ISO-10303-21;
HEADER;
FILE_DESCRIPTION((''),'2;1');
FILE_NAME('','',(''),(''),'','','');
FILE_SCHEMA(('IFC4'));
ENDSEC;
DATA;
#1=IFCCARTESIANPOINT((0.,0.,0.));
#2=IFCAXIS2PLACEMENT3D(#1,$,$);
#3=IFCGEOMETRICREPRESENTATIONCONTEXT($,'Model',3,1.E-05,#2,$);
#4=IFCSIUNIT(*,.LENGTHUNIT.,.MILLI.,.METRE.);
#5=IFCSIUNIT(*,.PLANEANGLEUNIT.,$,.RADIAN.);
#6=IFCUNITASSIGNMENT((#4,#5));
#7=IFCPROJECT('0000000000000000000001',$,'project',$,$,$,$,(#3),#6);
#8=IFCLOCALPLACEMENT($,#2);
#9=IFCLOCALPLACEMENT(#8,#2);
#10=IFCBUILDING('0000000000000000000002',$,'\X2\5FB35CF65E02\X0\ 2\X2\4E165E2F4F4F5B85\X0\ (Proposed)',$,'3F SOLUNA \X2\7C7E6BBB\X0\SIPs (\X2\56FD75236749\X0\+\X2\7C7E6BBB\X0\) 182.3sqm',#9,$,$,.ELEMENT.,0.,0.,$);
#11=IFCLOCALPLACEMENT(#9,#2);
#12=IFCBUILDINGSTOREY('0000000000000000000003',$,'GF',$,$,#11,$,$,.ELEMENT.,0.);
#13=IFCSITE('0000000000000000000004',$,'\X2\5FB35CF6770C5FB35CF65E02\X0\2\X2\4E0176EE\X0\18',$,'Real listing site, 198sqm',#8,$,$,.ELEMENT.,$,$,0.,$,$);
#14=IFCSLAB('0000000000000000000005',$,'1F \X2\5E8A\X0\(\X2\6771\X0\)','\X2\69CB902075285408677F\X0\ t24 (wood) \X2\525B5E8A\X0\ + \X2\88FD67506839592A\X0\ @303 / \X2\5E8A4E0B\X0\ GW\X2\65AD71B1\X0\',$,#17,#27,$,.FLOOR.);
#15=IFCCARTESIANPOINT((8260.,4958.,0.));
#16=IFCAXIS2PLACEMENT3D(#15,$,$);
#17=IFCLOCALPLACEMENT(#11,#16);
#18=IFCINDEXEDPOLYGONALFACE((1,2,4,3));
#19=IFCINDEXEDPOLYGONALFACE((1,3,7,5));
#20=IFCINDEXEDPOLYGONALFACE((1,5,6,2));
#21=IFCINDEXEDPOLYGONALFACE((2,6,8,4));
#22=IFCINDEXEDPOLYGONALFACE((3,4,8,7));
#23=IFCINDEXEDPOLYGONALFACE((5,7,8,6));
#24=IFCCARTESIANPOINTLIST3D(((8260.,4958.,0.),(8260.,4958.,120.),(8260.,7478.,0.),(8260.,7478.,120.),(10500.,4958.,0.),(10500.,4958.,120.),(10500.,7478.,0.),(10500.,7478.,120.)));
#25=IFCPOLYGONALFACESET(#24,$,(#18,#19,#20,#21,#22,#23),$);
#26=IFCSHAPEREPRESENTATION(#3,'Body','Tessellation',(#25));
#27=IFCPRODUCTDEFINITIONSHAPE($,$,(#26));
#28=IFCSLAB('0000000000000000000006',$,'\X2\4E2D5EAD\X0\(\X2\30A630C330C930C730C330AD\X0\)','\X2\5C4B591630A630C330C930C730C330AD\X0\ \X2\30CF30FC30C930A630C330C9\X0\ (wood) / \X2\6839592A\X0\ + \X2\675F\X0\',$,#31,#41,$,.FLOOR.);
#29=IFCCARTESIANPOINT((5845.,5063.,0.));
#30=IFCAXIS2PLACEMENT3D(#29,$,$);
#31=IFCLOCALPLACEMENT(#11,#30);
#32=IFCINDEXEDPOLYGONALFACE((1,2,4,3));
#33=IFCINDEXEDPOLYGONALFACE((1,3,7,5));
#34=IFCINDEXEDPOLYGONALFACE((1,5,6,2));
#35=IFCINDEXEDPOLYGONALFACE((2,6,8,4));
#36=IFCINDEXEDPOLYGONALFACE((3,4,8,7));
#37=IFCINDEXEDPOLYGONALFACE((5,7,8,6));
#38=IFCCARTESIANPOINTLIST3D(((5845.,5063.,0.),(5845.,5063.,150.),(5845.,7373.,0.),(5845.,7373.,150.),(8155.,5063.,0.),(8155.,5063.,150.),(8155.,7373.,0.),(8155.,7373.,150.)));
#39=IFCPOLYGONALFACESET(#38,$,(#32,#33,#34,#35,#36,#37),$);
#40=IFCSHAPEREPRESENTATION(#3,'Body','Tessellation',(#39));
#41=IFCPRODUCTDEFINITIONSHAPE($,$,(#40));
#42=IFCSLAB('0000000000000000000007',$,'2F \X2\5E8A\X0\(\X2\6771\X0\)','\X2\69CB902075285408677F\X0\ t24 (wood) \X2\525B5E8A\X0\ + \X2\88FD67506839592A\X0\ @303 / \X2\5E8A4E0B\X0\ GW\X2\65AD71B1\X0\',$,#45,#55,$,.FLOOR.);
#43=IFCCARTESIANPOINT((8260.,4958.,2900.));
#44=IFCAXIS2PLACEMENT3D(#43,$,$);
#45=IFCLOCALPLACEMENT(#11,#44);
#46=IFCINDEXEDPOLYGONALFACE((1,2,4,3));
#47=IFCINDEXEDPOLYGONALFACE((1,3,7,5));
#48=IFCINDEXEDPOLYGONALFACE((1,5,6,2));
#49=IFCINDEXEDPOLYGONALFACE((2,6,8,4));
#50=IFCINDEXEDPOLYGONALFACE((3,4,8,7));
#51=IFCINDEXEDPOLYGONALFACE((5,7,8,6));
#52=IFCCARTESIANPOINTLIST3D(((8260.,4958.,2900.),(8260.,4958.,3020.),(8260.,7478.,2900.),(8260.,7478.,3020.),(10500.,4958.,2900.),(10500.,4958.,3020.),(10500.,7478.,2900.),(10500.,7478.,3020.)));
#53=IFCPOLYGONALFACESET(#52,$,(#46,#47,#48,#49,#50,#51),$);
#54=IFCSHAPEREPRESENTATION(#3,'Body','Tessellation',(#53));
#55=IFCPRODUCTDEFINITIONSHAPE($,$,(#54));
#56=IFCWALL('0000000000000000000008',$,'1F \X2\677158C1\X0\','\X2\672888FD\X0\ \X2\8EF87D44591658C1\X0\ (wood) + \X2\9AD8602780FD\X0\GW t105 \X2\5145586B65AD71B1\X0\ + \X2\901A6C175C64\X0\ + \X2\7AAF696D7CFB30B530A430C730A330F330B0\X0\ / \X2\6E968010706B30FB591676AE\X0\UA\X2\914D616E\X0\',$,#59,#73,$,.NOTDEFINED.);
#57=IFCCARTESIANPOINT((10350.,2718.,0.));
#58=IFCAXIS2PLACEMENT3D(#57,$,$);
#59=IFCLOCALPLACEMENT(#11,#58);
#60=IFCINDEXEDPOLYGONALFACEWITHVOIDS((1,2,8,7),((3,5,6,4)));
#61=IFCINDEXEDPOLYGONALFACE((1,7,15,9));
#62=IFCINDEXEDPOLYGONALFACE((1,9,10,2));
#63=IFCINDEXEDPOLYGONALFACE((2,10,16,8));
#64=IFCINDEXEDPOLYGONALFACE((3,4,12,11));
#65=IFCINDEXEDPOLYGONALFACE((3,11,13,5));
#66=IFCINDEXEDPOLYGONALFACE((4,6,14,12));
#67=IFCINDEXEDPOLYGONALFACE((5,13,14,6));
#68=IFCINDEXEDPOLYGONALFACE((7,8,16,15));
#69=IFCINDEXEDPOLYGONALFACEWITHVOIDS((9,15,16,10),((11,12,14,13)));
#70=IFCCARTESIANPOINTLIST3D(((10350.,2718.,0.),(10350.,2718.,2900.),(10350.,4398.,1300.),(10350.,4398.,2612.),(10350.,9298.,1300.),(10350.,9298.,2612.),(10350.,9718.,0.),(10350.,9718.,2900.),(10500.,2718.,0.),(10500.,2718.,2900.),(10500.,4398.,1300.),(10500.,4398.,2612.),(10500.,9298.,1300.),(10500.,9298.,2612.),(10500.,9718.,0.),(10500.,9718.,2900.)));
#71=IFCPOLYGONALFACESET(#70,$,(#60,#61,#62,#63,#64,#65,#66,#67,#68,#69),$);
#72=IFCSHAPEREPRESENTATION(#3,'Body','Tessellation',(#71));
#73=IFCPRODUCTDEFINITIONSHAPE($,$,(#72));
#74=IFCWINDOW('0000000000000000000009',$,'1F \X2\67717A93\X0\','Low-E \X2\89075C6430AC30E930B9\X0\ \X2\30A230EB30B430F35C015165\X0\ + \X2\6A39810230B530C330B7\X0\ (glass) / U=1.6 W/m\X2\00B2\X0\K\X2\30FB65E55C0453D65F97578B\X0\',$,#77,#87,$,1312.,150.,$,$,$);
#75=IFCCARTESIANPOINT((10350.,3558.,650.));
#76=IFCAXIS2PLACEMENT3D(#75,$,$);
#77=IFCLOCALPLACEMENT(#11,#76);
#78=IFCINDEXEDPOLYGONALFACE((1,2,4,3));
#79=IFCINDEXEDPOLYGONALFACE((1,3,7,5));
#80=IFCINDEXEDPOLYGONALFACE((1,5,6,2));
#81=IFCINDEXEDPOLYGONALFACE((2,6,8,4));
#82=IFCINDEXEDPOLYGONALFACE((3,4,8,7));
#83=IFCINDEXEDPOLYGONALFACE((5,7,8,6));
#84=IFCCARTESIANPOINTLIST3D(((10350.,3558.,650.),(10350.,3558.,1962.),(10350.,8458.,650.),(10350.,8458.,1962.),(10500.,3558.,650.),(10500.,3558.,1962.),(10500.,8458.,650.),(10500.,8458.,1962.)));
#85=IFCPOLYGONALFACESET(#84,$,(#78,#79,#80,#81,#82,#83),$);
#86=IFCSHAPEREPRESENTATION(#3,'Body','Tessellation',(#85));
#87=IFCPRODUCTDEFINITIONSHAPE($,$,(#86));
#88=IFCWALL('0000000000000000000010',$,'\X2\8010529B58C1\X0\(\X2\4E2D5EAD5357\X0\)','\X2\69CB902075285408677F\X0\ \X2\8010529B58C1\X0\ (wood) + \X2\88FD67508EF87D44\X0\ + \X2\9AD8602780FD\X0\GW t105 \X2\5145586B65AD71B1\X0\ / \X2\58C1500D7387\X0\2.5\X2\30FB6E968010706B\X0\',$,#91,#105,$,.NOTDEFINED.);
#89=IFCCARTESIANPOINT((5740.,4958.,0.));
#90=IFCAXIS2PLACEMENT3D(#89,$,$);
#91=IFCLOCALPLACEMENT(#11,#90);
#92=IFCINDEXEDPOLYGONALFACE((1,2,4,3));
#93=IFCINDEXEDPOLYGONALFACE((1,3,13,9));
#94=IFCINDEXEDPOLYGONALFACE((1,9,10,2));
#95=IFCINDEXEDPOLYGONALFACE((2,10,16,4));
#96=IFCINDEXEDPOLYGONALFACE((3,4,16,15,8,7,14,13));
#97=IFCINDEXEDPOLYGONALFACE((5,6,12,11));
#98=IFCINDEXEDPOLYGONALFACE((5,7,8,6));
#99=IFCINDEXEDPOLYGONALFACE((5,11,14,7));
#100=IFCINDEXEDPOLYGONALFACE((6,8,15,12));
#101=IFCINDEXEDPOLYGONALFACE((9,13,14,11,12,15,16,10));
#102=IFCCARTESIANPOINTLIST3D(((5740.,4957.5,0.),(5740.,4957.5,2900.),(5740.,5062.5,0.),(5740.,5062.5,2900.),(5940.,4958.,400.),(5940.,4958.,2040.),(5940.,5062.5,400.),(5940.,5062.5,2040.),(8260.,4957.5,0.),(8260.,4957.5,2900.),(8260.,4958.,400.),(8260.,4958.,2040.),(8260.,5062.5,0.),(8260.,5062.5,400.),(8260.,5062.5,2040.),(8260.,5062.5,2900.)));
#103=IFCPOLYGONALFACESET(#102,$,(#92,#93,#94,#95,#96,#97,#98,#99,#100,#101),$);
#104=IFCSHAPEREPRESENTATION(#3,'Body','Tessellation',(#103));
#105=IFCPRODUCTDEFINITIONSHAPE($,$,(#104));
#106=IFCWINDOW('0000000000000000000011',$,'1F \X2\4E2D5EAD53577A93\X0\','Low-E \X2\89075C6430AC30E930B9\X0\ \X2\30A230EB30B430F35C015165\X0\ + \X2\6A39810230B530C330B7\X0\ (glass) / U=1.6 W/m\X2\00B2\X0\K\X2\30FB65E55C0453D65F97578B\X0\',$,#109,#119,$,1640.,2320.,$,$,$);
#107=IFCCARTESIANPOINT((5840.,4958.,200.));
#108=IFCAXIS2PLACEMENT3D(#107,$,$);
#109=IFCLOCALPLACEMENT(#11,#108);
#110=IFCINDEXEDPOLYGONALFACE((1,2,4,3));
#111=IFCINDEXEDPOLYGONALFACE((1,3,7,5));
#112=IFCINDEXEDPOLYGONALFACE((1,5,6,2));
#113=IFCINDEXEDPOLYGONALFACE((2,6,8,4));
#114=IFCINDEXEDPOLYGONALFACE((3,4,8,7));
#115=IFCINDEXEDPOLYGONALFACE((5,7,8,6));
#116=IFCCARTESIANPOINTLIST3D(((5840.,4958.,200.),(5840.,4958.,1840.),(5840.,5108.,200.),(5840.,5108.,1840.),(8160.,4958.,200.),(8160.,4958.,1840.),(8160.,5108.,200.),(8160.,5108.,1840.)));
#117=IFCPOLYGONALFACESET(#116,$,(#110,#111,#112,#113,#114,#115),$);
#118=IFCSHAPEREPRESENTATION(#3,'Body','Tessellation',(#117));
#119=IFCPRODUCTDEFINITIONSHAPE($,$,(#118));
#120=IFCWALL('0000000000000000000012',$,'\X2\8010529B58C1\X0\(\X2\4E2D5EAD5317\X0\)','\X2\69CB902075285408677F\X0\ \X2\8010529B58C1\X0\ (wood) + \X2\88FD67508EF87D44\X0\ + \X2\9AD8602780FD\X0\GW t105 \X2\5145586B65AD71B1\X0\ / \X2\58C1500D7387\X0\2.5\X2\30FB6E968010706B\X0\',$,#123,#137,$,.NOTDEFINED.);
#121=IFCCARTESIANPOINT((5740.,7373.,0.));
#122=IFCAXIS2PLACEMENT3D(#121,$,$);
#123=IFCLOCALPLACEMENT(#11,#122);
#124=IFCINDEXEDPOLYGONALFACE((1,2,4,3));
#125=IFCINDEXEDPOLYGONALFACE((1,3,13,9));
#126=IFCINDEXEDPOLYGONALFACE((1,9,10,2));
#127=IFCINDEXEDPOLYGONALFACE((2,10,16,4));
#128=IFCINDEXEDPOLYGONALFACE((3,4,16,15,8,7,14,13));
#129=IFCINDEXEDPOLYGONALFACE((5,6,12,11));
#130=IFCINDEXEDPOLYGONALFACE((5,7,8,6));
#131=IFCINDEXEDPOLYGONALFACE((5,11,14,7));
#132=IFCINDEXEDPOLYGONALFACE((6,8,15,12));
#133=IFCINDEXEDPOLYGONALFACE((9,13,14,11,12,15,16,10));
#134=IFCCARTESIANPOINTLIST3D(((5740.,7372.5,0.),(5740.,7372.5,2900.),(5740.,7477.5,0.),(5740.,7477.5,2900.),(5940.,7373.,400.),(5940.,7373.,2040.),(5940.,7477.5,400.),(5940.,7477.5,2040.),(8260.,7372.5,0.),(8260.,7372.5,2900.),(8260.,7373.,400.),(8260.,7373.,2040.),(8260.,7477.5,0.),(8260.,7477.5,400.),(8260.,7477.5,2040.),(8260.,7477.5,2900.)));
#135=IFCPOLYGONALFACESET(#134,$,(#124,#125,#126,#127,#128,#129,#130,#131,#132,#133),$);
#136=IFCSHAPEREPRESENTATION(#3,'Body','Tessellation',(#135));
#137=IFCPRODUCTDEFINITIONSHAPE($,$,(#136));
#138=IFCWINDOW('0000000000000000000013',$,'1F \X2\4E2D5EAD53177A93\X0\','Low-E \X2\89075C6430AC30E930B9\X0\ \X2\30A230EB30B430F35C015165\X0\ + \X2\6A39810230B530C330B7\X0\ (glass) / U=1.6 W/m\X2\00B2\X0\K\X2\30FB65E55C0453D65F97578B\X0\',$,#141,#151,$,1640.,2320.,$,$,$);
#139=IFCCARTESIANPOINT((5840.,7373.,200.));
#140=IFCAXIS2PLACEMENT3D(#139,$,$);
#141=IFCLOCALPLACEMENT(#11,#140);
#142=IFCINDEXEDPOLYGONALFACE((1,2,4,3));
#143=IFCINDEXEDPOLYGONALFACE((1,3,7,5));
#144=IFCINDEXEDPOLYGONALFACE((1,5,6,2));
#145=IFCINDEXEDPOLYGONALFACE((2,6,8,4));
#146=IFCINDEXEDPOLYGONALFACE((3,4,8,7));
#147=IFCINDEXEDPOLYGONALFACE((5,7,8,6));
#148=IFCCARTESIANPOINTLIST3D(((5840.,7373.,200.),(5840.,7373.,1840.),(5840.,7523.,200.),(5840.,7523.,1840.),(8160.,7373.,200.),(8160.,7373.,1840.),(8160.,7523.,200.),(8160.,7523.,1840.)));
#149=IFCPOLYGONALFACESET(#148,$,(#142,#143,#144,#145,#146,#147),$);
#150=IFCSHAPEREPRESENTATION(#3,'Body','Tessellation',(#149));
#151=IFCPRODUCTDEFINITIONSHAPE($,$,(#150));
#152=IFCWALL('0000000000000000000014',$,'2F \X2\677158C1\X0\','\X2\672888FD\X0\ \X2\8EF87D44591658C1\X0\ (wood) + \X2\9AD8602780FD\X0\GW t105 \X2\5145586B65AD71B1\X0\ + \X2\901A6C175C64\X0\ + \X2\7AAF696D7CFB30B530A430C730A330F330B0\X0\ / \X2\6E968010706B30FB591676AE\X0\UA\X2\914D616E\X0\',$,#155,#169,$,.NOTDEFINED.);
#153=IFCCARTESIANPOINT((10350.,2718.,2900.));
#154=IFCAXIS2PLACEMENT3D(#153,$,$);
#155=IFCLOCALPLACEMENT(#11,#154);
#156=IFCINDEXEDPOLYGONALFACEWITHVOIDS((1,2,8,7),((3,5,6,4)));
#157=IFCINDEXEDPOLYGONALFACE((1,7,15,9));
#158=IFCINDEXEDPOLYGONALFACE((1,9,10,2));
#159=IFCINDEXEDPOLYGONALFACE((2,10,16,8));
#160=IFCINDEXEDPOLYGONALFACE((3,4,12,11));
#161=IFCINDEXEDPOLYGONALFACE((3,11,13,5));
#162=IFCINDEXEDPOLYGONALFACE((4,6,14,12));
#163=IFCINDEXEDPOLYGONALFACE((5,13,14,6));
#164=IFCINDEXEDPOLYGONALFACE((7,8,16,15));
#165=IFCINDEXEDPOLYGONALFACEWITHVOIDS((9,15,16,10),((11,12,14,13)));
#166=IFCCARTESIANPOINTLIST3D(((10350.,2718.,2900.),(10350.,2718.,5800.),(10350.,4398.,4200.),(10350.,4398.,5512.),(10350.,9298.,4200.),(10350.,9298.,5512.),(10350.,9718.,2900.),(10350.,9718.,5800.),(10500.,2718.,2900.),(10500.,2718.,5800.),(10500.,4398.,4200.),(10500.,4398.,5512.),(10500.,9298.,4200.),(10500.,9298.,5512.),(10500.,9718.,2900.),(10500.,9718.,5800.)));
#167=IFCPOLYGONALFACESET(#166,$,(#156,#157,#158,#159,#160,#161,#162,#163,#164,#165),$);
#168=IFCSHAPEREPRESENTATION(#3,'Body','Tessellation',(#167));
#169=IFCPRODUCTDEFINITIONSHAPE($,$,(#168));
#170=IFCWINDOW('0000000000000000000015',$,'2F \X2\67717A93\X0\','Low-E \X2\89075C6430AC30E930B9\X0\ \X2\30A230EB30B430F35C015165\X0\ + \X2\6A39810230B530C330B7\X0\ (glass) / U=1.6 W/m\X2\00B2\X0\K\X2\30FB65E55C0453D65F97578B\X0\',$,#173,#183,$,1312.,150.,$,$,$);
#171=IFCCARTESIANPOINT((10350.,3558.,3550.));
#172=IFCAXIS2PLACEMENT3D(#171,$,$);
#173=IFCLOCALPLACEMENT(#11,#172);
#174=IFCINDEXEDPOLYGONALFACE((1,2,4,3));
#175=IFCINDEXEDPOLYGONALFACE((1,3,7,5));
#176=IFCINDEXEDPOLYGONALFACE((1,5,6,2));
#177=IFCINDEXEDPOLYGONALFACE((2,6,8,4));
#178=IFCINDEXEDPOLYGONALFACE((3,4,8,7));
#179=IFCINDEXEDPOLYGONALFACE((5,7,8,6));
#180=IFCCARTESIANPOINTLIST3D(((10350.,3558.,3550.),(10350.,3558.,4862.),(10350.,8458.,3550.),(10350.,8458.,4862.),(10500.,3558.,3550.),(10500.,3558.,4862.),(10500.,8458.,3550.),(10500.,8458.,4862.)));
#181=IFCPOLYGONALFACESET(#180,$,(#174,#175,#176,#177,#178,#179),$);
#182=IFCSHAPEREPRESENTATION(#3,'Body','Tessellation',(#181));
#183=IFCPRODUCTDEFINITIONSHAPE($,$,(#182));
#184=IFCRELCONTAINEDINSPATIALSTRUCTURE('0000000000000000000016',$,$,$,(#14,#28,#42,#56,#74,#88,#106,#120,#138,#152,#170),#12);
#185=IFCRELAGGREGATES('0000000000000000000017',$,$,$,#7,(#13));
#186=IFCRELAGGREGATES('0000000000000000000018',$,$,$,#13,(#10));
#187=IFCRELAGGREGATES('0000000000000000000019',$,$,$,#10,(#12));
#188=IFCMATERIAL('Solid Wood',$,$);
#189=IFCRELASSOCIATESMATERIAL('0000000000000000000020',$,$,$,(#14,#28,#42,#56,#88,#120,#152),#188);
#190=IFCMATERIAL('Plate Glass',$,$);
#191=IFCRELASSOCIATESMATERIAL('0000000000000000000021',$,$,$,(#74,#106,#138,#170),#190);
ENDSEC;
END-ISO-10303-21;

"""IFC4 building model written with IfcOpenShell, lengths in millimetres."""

from ifc_helpers import new_model, si_unit, frame, frame_2d, origin, place, context, project, spatial, rectangle, extrude, material, element, fill, save


model = new_model("IFC4")

# Units and contexts
model_context = context("Model", 3, precision=1e-05, world=origin())
ifc_project = project(units=[si_unit("LENGTHUNIT", "METRE", prefix="MILLI"), si_unit("PLANEANGLEUNIT", "RADIAN")], contexts=[model_context])

# Site, building, storey
site_placement = place(None, origin())
site = spatial("IfcSite", under=ifc_project, at=site_placement, Name="徳島県徳島市2丁目18", ObjectType="Real listing site, 198sqm", CompositionType="ELEMENT", RefElevation=0.0)
building_placement = place(site_placement, origin())
building = spatial("IfcBuilding", under=site, at=building_placement, Name="徳島市 2世帯住宅 (Proposed)", ObjectType="3F SOLUNA 籾殻SIPs (国産杉+籾殻) 182.3sqm", CompositionType="ELEMENT", ElevationOfRefHeight=0.0, ElevationOfTerrain=0.0)
storey_placement = place(building_placement, origin())
storey = spatial("IfcBuildingStorey", under=building, at=storey_placement, Name="GF", CompositionType="ELEMENT", Elevation=0.0)

# Slabs
ifc_material_1 = material(Name="Solid Wood")
slab_1_placement = place(storey_placement, frame((8260.0, 4958.0, 0.0)))
element("IfcSlab", 1, at=slab_1_placement, inside=storey, material=ifc_material_1, Name="1F 床(東)", Description="構造用合板 t24 (wood) 剛床 + 製材根太 @303 / 床下 GW断熱", PredefinedType="FLOOR", context=model_context, shape_type="SweptSolid", body=[
    extrude(rectangle(XDim=2240.0, YDim=2520.0, at=frame_2d((1120.0, 1260.0))), frame((8260.0, 4958.0, 0.0)), (0.0, 0.0, 1.0), 120.0),
])
slab_2_placement = place(storey_placement, frame((5845.0, 5063.0, 0.0)))
element("IfcSlab", 2, at=slab_2_placement, inside=storey, material=ifc_material_1, Name="中庭(ウッドデッキ)", Description="屋外ウッドデッキ ハードウッド (wood) / 根太 + 束", PredefinedType="FLOOR", context=model_context, shape_type="SweptSolid", body=[
    extrude(rectangle(XDim=2310.0, YDim=2310.0, at=frame_2d((1155.0, 1155.0))), frame((5845.0, 5063.0, 0.0)), (0.0, 0.0, 1.0), 150.0),
])
slab_3_placement = place(storey_placement, frame((8260.0, 4958.0, 2900.0)))
element("IfcSlab", 3, at=slab_3_placement, inside=storey, material=ifc_material_1, Name="2F 床(東)", Description="構造用合板 t24 (wood) 剛床 + 製材根太 @303 / 床下 GW断熱", PredefinedType="FLOOR", context=model_context, shape_type="SweptSolid", body=[
    extrude(rectangle(XDim=2240.0, YDim=2520.0, at=frame_2d((1120.0, 1260.0))), frame((8260.0, 4958.0, 2900.0)), (0.0, 0.0, 1.0), 120.0),
])

# Walls, openings, windows
wall_1_placement = place(storey_placement, frame((10350.0, 2718.0, 0.0)))
wall_1 = element("IfcWall", 4, at=wall_1_placement, inside=storey, material=ifc_material_1, Name="1F 東壁", Description="木製 軸組外壁 (wood) + 高性能GW t105 充填断熱 + 通気層 + 窯業系サイディング / 準耐火・外皮UA配慮", PredefinedType="NOTDEFINED", context=model_context, shape_type="SweptSolid", body=[
    extrude(rectangle(XDim=150.0, YDim=7000.0, at=frame_2d((75.0, 3500.0))), frame((10350.0, 2718.0, 0.0)), (0.0, 0.0, 1.0), 2900.0),
])
opening_1_placement = place(storey_placement, frame((10350.0, 3558.0, 650.0)))
opening_1 = element("IfcOpeningElement", 5, at=opening_1_placement, cuts=wall_1, PredefinedType="NOTDEFINED", context=model_context, shape_type="SweptSolid", body=[
    extrude(rectangle(XDim=150.0, YDim=4900.0, at=frame_2d((75.0, 2450.0))), frame((10350.0, 3558.0, 650.0)), (0.0, 0.0, 1.0), 1312.0),
])
ifc_material_2 = material(Name="Plate Glass")
window_1_placement = place(storey_placement, frame((10350.0, 3558.0, 650.0)))
window_1 = element("IfcWindow", 6, at=window_1_placement, inside=storey, material=ifc_material_2, Name="1F 東窓", Description="Low-E 複層ガラス アルゴン封入 + 樹脂サッシ (glass) / U=1.6 W/m²K・日射取得型", OverallHeight=1312.0, OverallWidth=150.0, context=model_context, shape_type="SweptSolid", body=[
    extrude(rectangle(XDim=150.0, YDim=4900.0, at=frame_2d((75.0, 2450.0))), frame((10350.0, 3558.0, 650.0)), (0.0, 0.0, 1.0), 1312.0),
])
fill(opening_1, window_1)
wall_2_placement = place(storey_placement, frame((5740.0, 4958.0, 0.0)))
wall_2 = element("IfcWall", 7, at=wall_2_placement, inside=storey, material=ifc_material_1, Name="耐力壁(中庭南)", Description="構造用合板 耐力壁 (wood) + 製材軸組 + 高性能GW t105 充填断熱 / 壁倍率2.5・準耐火", PredefinedType="NOTDEFINED", context=model_context, shape_type="SweptSolid", body=[
    extrude(rectangle(XDim=2520.0, YDim=105.0, at=frame_2d((1260.0, 52.0))), frame((5740.0, 4958.0, 0.0)), (0.0, 0.0, 1.0), 2900.0),
])
opening_2_placement = place(storey_placement, frame((5840.0, 4958.0, 200.0)))
opening_2 = element("IfcOpeningElement", 8, at=opening_2_placement, cuts=wall_2, PredefinedType="NOTDEFINED", context=model_context, shape_type="SweptSolid", body=[
    extrude(rectangle(XDim=2320.0, YDim=150.0, at=frame_2d((1160.0, 75.0))), frame((5840.0, 4958.0, 200.0)), (0.0, 0.0, 1.0), 1640.0),
])
window_2_placement = place(storey_placement, frame((5840.0, 4958.0, 200.0)))
window_2 = element("IfcWindow", 9, at=window_2_placement, inside=storey, material=ifc_material_2, Name="1F 中庭南窓", Description="Low-E 複層ガラス アルゴン封入 + 樹脂サッシ (glass) / U=1.6 W/m²K・日射取得型", OverallHeight=1640.0, OverallWidth=2320.0, context=model_context, shape_type="SweptSolid", body=[
    extrude(rectangle(XDim=2320.0, YDim=150.0, at=frame_2d((1160.0, 75.0))), frame((5840.0, 4958.0, 200.0)), (0.0, 0.0, 1.0), 1640.0),
])
fill(opening_2, window_2)
wall_3_placement = place(storey_placement, frame((5740.0, 7373.0, 0.0)))
wall_3 = element("IfcWall", 10, at=wall_3_placement, inside=storey, material=ifc_material_1, Name="耐力壁(中庭北)", Description="構造用合板 耐力壁 (wood) + 製材軸組 + 高性能GW t105 充填断熱 / 壁倍率2.5・準耐火", PredefinedType="NOTDEFINED", context=model_context, shape_type="SweptSolid", body=[
    extrude(rectangle(XDim=2520.0, YDim=105.0, at=frame_2d((1260.0, 52.0))), frame((5740.0, 7373.0, 0.0)), (0.0, 0.0, 1.0), 2900.0),
])
opening_3_placement = place(storey_placement, frame((5840.0, 7373.0, 200.0)))
opening_3 = element("IfcOpeningElement", 11, at=opening_3_placement, cuts=wall_3, PredefinedType="NOTDEFINED", context=model_context, shape_type="SweptSolid", body=[
    extrude(rectangle(XDim=2320.0, YDim=150.0, at=frame_2d((1160.0, 75.0))), frame((5840.0, 7373.0, 200.0)), (0.0, 0.0, 1.0), 1640.0),
])
window_3_placement = place(storey_placement, frame((5840.0, 7373.0, 200.0)))
window_3 = element("IfcWindow", 12, at=window_3_placement, inside=storey, material=ifc_material_2, Name="1F 中庭北窓", Description="Low-E 複層ガラス アルゴン封入 + 樹脂サッシ (glass) / U=1.6 W/m²K・日射取得型", OverallHeight=1640.0, OverallWidth=2320.0, context=model_context, shape_type="SweptSolid", body=[
    extrude(rectangle(XDim=2320.0, YDim=150.0, at=frame_2d((1160.0, 75.0))), frame((5840.0, 7373.0, 200.0)), (0.0, 0.0, 1.0), 1640.0),
])
fill(opening_3, window_3)

# Wall, opening, window
wall_4_placement = place(storey_placement, frame((10350.0, 2718.0, 2900.0)))
wall_4 = element("IfcWall", 13, at=wall_4_placement, inside=storey, material=ifc_material_1, Name="2F 東壁", Description="木製 軸組外壁 (wood) + 高性能GW t105 充填断熱 + 通気層 + 窯業系サイディング / 準耐火・外皮UA配慮", PredefinedType="NOTDEFINED", context=model_context, shape_type="SweptSolid", body=[
    extrude(rectangle(XDim=150.0, YDim=7000.0, at=frame_2d((75.0, 3500.0))), frame((10350.0, 2718.0, 2900.0)), (0.0, 0.0, 1.0), 2900.0),
])
opening_4_placement = place(storey_placement, frame((10350.0, 3558.0, 3550.0)))
opening_4 = element("IfcOpeningElement", 14, at=opening_4_placement, cuts=wall_4, PredefinedType="NOTDEFINED", context=model_context, shape_type="SweptSolid", body=[
    extrude(rectangle(XDim=150.0, YDim=4900.0, at=frame_2d((75.0, 2450.0))), frame((10350.0, 3558.0, 3550.0)), (0.0, 0.0, 1.0), 1312.0),
])
window_4_placement = place(storey_placement, frame((10350.0, 3558.0, 3550.0)))
window_4 = element("IfcWindow", 15, at=window_4_placement, inside=storey, material=ifc_material_2, Name="2F 東窓", Description="Low-E 複層ガラス アルゴン封入 + 樹脂サッシ (glass) / U=1.6 W/m²K・日射取得型", OverallHeight=1312.0, OverallWidth=150.0, context=model_context, shape_type="SweptSolid", body=[
    extrude(rectangle(XDim=150.0, YDim=4900.0, at=frame_2d((75.0, 2450.0))), frame((10350.0, 3558.0, 3550.0)), (0.0, 0.0, 1.0), 1312.0),
])
fill(opening_4, window_4)

save(model, "model.ifc")
